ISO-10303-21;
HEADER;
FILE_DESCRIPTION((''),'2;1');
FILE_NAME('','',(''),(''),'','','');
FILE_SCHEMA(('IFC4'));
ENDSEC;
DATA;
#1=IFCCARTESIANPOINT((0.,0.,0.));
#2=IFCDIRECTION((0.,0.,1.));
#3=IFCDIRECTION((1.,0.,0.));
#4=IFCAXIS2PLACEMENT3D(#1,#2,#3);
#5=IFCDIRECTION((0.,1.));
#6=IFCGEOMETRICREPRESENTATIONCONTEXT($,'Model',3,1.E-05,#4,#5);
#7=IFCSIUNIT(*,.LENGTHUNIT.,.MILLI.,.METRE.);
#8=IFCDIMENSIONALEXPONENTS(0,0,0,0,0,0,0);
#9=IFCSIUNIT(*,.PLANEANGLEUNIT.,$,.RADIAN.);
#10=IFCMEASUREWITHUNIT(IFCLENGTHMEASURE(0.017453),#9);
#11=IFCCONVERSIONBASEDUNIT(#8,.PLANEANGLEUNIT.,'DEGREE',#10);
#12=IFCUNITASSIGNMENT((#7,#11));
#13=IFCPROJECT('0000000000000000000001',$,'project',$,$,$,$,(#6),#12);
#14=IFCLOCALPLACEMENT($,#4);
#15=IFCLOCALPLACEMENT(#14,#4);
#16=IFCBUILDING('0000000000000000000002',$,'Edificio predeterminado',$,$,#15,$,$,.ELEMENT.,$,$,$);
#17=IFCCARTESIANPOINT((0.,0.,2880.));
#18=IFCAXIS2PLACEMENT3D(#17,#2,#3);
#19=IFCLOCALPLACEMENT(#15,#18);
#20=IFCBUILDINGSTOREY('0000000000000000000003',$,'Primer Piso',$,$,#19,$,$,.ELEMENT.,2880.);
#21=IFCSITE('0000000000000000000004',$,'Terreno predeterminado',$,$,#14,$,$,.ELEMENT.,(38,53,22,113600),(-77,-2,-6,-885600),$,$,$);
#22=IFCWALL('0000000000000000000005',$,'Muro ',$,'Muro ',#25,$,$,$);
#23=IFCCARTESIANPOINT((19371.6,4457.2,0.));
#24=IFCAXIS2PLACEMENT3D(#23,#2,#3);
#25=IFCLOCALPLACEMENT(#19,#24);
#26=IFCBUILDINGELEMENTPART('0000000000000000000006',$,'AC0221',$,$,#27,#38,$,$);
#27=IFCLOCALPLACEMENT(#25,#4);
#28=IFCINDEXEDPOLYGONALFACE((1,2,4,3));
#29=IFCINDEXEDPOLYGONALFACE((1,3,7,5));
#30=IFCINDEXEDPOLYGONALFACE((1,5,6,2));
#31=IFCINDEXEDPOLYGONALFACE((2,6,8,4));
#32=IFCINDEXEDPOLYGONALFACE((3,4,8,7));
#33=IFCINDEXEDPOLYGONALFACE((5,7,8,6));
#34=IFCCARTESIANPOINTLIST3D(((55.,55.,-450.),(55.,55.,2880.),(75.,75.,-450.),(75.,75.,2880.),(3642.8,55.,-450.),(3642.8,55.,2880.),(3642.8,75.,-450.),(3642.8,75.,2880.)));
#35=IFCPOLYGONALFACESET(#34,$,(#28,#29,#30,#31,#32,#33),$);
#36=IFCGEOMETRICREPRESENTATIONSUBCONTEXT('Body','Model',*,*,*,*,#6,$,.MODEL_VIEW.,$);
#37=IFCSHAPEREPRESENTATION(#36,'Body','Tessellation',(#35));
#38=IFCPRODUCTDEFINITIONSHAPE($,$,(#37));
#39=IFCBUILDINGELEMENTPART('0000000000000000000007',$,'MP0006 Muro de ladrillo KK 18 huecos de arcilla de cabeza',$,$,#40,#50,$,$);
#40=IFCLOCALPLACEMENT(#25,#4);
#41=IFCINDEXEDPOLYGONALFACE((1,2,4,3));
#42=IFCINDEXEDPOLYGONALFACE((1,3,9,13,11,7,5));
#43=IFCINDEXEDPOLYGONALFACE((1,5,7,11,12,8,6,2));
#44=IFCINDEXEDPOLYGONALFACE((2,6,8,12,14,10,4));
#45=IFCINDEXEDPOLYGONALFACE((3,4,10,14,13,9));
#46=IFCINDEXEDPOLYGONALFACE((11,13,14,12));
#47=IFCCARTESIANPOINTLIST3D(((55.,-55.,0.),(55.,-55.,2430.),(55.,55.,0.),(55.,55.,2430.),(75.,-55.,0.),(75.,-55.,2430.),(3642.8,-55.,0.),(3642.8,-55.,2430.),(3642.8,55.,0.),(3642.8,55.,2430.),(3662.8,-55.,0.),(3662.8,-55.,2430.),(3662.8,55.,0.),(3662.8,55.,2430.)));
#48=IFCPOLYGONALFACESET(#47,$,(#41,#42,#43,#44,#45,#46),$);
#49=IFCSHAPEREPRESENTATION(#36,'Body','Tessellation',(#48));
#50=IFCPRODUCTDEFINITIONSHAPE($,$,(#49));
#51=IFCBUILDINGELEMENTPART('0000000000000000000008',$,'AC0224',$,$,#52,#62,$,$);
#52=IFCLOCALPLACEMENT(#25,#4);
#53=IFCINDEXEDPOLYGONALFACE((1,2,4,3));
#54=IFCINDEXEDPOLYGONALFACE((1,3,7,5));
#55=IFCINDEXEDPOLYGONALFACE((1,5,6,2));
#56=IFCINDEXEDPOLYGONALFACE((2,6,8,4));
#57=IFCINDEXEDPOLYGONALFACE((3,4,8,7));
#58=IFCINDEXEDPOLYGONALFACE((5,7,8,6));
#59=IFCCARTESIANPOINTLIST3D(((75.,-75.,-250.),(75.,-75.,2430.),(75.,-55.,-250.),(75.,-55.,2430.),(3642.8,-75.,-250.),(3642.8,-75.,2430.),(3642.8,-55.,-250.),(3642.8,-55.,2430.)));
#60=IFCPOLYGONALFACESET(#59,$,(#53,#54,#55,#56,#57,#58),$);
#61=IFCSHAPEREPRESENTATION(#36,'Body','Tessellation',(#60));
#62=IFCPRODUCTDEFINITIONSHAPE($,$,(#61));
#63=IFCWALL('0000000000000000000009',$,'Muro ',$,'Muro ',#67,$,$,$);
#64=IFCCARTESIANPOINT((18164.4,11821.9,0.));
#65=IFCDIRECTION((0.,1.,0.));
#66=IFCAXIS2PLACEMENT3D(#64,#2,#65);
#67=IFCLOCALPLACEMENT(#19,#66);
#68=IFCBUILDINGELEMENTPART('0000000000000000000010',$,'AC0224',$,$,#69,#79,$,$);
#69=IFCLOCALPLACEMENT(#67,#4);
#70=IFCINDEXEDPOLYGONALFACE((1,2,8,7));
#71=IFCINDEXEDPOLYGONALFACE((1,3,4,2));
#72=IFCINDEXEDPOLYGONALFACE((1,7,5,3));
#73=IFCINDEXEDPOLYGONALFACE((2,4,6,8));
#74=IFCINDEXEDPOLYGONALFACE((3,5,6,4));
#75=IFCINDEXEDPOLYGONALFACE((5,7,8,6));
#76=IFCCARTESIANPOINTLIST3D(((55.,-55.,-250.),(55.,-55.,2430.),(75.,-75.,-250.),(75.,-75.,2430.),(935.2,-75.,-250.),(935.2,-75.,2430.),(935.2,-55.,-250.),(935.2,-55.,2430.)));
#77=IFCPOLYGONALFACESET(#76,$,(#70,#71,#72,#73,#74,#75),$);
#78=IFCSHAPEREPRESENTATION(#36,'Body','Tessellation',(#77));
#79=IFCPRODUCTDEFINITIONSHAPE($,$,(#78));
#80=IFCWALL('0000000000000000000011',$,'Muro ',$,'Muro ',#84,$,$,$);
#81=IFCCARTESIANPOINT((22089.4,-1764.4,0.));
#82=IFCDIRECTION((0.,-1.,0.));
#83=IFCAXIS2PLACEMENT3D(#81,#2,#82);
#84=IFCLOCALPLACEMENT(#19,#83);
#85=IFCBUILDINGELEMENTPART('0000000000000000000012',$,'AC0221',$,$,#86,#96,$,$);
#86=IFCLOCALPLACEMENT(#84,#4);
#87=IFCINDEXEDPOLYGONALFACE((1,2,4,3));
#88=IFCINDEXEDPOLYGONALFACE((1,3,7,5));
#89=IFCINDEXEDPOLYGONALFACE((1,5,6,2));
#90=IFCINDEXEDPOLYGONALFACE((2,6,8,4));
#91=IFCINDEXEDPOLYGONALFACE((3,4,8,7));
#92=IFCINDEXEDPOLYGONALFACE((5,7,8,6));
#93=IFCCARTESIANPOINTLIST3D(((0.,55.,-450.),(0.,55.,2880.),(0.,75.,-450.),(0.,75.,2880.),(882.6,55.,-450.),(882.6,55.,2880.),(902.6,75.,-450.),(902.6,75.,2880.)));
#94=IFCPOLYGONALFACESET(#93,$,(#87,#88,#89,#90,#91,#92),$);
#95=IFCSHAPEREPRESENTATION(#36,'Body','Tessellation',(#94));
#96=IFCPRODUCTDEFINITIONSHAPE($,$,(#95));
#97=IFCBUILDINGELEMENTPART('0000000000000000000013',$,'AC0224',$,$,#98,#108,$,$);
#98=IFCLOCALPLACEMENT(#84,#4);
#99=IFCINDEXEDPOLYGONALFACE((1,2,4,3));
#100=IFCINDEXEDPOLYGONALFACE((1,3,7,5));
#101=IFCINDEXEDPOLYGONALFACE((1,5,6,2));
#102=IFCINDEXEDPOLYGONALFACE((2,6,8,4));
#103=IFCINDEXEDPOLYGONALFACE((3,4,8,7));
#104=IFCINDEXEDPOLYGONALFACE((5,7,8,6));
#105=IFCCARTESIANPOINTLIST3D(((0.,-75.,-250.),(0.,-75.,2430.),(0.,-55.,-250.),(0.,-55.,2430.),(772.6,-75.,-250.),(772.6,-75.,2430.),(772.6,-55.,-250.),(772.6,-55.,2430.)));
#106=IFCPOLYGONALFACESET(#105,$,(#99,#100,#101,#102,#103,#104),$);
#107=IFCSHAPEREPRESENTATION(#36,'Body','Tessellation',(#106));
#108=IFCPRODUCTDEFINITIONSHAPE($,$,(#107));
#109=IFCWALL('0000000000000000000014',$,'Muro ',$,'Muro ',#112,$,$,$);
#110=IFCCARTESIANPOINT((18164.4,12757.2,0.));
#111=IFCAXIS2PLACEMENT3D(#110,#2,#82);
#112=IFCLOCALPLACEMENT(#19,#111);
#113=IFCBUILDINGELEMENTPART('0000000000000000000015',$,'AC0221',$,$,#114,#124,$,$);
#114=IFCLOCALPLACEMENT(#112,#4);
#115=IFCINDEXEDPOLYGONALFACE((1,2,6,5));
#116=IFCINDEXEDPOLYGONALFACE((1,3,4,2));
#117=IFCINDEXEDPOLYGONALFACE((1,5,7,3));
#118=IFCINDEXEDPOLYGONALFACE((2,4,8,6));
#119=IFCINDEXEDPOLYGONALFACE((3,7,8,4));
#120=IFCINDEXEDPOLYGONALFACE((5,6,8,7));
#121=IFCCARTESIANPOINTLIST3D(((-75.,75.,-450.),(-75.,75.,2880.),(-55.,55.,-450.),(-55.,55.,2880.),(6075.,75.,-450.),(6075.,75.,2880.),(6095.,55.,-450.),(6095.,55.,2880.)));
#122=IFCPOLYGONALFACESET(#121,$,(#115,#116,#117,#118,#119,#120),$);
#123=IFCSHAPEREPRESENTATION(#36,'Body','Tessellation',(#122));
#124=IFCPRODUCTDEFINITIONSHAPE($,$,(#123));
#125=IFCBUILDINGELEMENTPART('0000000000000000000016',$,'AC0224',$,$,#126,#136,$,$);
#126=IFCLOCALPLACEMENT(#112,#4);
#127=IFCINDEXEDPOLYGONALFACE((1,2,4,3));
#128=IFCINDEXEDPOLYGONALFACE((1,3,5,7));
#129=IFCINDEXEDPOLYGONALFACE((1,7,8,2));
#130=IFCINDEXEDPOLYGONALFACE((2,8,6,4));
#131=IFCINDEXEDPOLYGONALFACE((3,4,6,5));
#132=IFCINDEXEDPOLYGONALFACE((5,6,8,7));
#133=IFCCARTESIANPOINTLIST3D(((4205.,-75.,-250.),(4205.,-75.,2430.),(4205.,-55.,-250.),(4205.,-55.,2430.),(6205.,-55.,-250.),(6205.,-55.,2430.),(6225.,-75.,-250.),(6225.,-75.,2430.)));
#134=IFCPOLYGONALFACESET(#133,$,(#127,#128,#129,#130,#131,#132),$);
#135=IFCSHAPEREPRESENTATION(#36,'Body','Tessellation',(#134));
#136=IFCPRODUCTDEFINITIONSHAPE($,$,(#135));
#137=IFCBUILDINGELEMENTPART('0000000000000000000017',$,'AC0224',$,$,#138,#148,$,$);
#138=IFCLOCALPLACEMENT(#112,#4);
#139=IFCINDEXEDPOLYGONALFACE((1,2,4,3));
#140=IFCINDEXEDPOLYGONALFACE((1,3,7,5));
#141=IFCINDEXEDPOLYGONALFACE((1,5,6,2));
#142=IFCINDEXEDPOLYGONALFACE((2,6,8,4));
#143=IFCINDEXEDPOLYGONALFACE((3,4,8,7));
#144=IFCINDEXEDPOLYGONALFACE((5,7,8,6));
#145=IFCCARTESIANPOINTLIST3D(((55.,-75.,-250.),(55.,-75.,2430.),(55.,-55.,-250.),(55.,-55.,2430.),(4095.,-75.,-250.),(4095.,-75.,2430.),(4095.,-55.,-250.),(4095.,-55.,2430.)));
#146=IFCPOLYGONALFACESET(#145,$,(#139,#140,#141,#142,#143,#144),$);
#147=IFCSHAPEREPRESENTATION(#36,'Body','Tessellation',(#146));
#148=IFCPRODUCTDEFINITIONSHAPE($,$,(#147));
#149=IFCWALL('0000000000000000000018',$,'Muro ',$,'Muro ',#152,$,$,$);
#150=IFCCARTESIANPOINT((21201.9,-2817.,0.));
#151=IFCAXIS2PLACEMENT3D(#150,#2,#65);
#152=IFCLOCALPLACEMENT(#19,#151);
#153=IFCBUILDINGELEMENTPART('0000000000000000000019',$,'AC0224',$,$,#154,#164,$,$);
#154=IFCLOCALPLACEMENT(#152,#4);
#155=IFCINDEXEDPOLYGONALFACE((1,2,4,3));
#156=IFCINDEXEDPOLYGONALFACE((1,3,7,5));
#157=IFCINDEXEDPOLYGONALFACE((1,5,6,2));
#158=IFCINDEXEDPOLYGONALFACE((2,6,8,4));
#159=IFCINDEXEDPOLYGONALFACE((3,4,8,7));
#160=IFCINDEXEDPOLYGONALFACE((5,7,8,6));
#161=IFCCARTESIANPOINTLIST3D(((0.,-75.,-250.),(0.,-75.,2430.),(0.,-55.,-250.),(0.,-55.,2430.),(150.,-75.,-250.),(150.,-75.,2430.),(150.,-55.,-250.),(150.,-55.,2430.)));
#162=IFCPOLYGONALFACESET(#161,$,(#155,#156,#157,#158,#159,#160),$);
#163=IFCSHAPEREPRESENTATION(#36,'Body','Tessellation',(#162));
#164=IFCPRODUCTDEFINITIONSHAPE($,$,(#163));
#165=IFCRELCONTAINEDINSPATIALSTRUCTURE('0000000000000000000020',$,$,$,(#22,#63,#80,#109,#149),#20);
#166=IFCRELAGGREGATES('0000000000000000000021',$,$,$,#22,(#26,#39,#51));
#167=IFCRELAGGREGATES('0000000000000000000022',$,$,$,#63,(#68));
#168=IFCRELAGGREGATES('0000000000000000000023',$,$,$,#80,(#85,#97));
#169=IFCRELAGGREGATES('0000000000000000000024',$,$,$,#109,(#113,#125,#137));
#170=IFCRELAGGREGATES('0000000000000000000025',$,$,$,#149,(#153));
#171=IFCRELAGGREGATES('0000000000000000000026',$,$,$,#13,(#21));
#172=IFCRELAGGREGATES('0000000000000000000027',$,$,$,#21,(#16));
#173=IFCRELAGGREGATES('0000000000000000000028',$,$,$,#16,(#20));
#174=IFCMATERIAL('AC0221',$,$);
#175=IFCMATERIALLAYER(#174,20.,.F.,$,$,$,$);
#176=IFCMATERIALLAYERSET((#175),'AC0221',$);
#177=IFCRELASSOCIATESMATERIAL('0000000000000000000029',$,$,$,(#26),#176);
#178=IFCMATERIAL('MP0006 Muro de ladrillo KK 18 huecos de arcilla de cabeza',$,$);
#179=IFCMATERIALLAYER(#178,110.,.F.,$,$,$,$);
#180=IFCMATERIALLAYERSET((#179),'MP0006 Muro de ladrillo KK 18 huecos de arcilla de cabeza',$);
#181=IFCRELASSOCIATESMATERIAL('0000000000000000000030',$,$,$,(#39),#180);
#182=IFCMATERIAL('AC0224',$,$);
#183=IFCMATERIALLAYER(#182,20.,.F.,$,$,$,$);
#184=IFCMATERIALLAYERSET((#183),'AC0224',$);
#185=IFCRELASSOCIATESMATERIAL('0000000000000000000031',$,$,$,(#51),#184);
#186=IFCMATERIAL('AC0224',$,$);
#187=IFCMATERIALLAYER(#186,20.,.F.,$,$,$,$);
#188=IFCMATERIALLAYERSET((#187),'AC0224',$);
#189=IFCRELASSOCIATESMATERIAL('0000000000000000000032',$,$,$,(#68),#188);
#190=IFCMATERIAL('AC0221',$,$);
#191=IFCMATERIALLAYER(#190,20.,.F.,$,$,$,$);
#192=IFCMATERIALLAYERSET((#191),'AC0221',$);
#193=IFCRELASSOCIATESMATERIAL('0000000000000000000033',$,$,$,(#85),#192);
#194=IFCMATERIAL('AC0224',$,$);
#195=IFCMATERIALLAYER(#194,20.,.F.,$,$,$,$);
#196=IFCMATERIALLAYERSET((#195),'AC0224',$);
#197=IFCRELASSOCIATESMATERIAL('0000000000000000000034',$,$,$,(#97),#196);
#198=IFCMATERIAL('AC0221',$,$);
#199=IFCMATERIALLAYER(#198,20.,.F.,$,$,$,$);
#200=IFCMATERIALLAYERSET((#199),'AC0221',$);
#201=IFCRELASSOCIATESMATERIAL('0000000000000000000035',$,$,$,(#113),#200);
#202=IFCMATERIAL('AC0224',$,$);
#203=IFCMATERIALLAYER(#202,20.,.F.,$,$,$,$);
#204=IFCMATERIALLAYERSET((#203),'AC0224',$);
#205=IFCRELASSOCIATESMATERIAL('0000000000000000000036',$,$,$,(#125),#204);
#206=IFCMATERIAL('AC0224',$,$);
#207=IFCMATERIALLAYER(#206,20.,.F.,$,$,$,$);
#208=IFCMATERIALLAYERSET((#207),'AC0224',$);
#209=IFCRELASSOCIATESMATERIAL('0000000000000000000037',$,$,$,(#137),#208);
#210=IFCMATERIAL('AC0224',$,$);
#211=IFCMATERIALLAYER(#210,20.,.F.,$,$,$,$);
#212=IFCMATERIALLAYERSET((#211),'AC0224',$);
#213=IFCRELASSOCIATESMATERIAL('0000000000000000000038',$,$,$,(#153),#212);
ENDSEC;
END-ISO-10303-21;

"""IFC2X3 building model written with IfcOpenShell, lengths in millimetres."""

from ifc_helpers import new_model, entity, si_unit, converted_unit, direction, frame, origin_with_axes, place, context, subcontext, project, spatial, polyline, outline, extrude, clip, bounded_halfspace, material, layer, layer_set, layer_usage, element, aggregate, save


model = new_model("IFC2X3")

# Units and contexts
model_context = context("Model", 3, precision=1e-05, world=origin_with_axes(), true_north=direction((0.0, 1.0)))
body_context = subcontext(model_context, "Body", "Model", "MODEL_VIEW")
ifc_project = project(units=[si_unit("LENGTHUNIT", "METRE", prefix="MILLI"), converted_unit("PLANEANGLEUNIT", "DEGREE", entity("IfcLengthMeasure", 0.017453), si_unit("PLANEANGLEUNIT", "RADIAN"), dimensions=[0, 0, 0, 0, 0, 0, 0])], contexts=[model_context])

# Site, building, storey
site_placement = place(None, origin_with_axes())
site = spatial("IfcSite", under=ifc_project, at=site_placement, Name="Terreno predeterminado", CompositionType="ELEMENT", RefLatitude=(38, 53, 22, 113600), RefLongitude=(-77, -2, -6, -885600))
building_placement = place(site_placement, origin_with_axes())
building = spatial("IfcBuilding", under=site, at=building_placement, Name="Edificio predeterminado", CompositionType="ELEMENT")
storey_placement = place(building_placement, frame((0.0, 0.0, 2880.0), z_axis=(0.0, 0.0, 1.0), x_axis=(1.0, 0.0, 0.0)))
storey = spatial("IfcBuildingStorey", under=building, at=storey_placement, Name="Primer Piso", CompositionType="ELEMENT", Elevation=2880.0)

# Walls, building element parts
wall_1_placement = place(storey_placement, frame((19371.6, 4457.2, 0.0), z_axis=(0.0, 0.0, 1.0), x_axis=(1.0, 0.0, 0.0)))
wall_1 = element("IfcWall", 1, at=wall_1_placement, inside=storey, Name="Muro ", ObjectType="Muro ")
ifc_material_1 = material(Name="AC0221")
ifc_layer_1 = layer(ifc_material_1, 20.0, ventilated=False)
ifc_layer_set_1 = layer_set([ifc_layer_1], Name="AC0221")
ifc_layer_usage_1 = layer_usage(ifc_layer_set_1, "AXIS2", "NEGATIVE", -75.0)
building_element_part_1_placement = place(wall_1_placement, origin_with_axes())
building_element_part_1 = element("IfcBuildingElementPart", 2, at=building_element_part_1_placement, material=ifc_layer_usage_1, Name="AC0221", context=body_context, shape_type="SweptSolid", body=[
    extrude(outline(polyline([(3642.8, 75.0), (3642.8, 55.0), (55.0, 55.0), (75.0, 75.0), (3642.8, 75.0)])), frame((0.0, 0.0, -450.0), z_axis=(0.0, 0.0, 1.0), x_axis=(1.0, 0.0, 0.0)), (0.0, 0.0, 1.0), 3330.0),
])
ifc_material_2 = material(Name="MP0006 Muro de ladrillo KK 18 huecos de arcilla de cabeza")
ifc_layer_2 = layer(ifc_material_2, 110.0, ventilated=False)
ifc_layer_set_2 = layer_set([ifc_layer_2], Name="MP0006 Muro de ladrillo KK 18 huecos de arcilla de cabeza")
ifc_layer_usage_2 = layer_usage(ifc_layer_set_2, "AXIS2", "NEGATIVE", -55.0)
building_element_part_2_placement = place(wall_1_placement, origin_with_axes())
building_element_part_2 = element("IfcBuildingElementPart", 3, at=building_element_part_2_placement, material=ifc_layer_usage_2, Name="MP0006 Muro de ladrillo KK 18 huecos de arcilla de cabeza", context=body_context, shape_type="SweptSolid", body=[
    extrude(outline(polyline([(3662.8, 55.0), (3662.8, -55.0), (3642.8, -55.0), (75.0, -55.0), (55.0, -55.0), (55.0, 55.0), (3642.8, 55.0), (3662.8, 55.0)])), origin_with_axes(), (0.0, 0.0, 1.0), 2430.0),
])
ifc_material_3 = material(Name="AC0224")
ifc_layer_3 = layer(ifc_material_3, 20.0, ventilated=False)
ifc_layer_set_3 = layer_set([ifc_layer_3], Name="AC0224")
ifc_layer_usage_3 = layer_usage(ifc_layer_set_3, "AXIS2", "NEGATIVE", 55.0)
building_element_part_3_placement = place(wall_1_placement, origin_with_axes())
building_element_part_3 = element("IfcBuildingElementPart", 4, at=building_element_part_3_placement, material=ifc_layer_usage_3, Name="AC0224", context=body_context, shape_type="SweptSolid", body=[
    extrude(outline(polyline([(3642.8, -55.0), (3642.8, -75.0), (75.0, -75.0), (75.0, -55.0), (3642.8, -55.0)])), frame((0.0, 0.0, -250.0), z_axis=(0.0, 0.0, 1.0), x_axis=(1.0, 0.0, 0.0)), (0.0, 0.0, 1.0), 2680.0),
])
aggregate(wall_1, [building_element_part_1, building_element_part_2, building_element_part_3])
wall_2_placement = place(storey_placement, frame((18164.4, 11821.9, 0.0), z_axis=(0.0, 0.0, 1.0), x_axis=(0.0, 1.0, 0.0)))
wall_2 = element("IfcWall", 5, at=wall_2_placement, inside=storey, Name="Muro ", ObjectType="Muro ")
ifc_material_4 = material(Name="AC0224")
ifc_layer_4 = layer(ifc_material_4, 20.0, ventilated=False)
ifc_layer_set_4 = layer_set([ifc_layer_4], Name="AC0224")
ifc_layer_usage_4 = layer_usage(ifc_layer_set_4, "AXIS2", "NEGATIVE", 55.0)
building_element_part_4_placement = place(wall_2_placement, origin_with_axes())
building_element_part_4 = element("IfcBuildingElementPart", 6, at=building_element_part_4_placement, material=ifc_layer_usage_4, Name="AC0224", context=body_context, shape_type="SweptSolid", body=[
    extrude(outline(polyline([(935.2, -55.0), (935.2, -75.0), (75.0, -75.0), (55.0, -55.0), (935.2, -55.0)])), frame((0.0, 0.0, -250.0), z_axis=(0.0, 0.0, 1.0), x_axis=(1.0, 0.0, 0.0)), (0.0, 0.0, 1.0), 2680.0),
])
aggregate(wall_2, [building_element_part_4])
wall_3_placement = place(storey_placement, frame((22089.4, -1764.4, 0.0), z_axis=(0.0, 0.0, 1.0), x_axis=(0.0, -1.0, 0.0)))
wall_3 = element("IfcWall", 7, at=wall_3_placement, inside=storey, Name="Muro ", ObjectType="Muro ")
ifc_material_5 = material(Name="AC0221")
ifc_layer_5 = layer(ifc_material_5, 20.0, ventilated=False)
ifc_layer_set_5 = layer_set([ifc_layer_5], Name="AC0221")
ifc_layer_usage_5 = layer_usage(ifc_layer_set_5, "AXIS2", "NEGATIVE", -75.0)
building_element_part_5_placement = place(wall_3_placement, origin_with_axes())
building_element_part_5 = element("IfcBuildingElementPart", 8, at=building_element_part_5_placement, material=ifc_layer_usage_5, Name="AC0221", context=body_context, shape_type="SweptSolid", body=[
    extrude(outline(polyline([(902.6, 75.0), (882.6, 55.0), (0.0, 55.0), (0.0, 75.0), (902.6, 75.0)])), frame((0.0, 0.0, -450.0), z_axis=(0.0, 0.0, 1.0), x_axis=(1.0, 0.0, 0.0)), (0.0, 0.0, 1.0), 3330.0),
])
ifc_material_6 = material(Name="AC0224")
ifc_layer_6 = layer(ifc_material_6, 20.0, ventilated=False)
ifc_layer_set_6 = layer_set([ifc_layer_6], Name="AC0224")
ifc_layer_usage_6 = layer_usage(ifc_layer_set_6, "AXIS2", "NEGATIVE", 55.0)
building_element_part_6_placement = place(wall_3_placement, origin_with_axes())
building_element_part_6 = element("IfcBuildingElementPart", 9, at=building_element_part_6_placement, material=ifc_layer_usage_6, Name="AC0224", context=body_context, shape_type="SweptSolid", body=[
    extrude(outline(polyline([(772.6, -55.0), (772.6, -75.0), (0.0, -75.0), (0.0, -55.0), (772.6, -55.0)])), frame((0.0, 0.0, -250.0), z_axis=(0.0, 0.0, 1.0), x_axis=(1.0, 0.0, 0.0)), (0.0, 0.0, 1.0), 2680.0),
])
aggregate(wall_3, [building_element_part_5, building_element_part_6])
wall_4_placement = place(storey_placement, frame((18164.4, 12757.2, 0.0), z_axis=(0.0, 0.0, 1.0), x_axis=(0.0, -1.0, 0.0)))
wall_4 = element("IfcWall", 10, at=wall_4_placement, inside=storey, Name="Muro ", ObjectType="Muro ")
ifc_material_7 = material(Name="AC0221")
ifc_layer_7 = layer(ifc_material_7, 20.0, ventilated=False)
ifc_layer_set_7 = layer_set([ifc_layer_7], Name="AC0221")
ifc_layer_usage_7 = layer_usage(ifc_layer_set_7, "AXIS2", "NEGATIVE", -75.0)
building_element_part_7_placement = place(wall_4_placement, origin_with_axes())
building_element_part_7 = element("IfcBuildingElementPart", 11, at=building_element_part_7_placement, material=ifc_layer_usage_7, Name="AC0221", context=body_context, shape_type="SweptSolid", body=[
    extrude(outline(polyline([(6075.0, 75.0), (6095.0, 55.0), (-55.0, 55.0), (-75.0, 75.0), (6075.0, 75.0)])), frame((0.0, 0.0, -450.0), z_axis=(0.0, 0.0, 1.0), x_axis=(1.0, 0.0, 0.0)), (0.0, 0.0, 1.0), 3330.0),
])
ifc_material_8 = material(Name="AC0224")
ifc_layer_8 = layer(ifc_material_8, 20.0, ventilated=False)
ifc_layer_set_8 = layer_set([ifc_layer_8], Name="AC0224")
ifc_layer_usage_8 = layer_usage(ifc_layer_set_8, "AXIS2", "NEGATIVE", 55.0)
building_element_part_8_placement = place(wall_4_placement, origin_with_axes())
building_element_part_8 = element("IfcBuildingElementPart", 12, at=building_element_part_8_placement, material=ifc_layer_usage_8, Name="AC0224", context=body_context, shape_type="SweptSolid", body=[
    extrude(outline(polyline([(6205.0, -55.0), (6225.0, -75.0), (4205.0, -75.0), (4205.0, -55.0), (6205.0, -55.0)])), frame((0.0, 0.0, -250.0), z_axis=(0.0, 0.0, 1.0), x_axis=(1.0, 0.0, 0.0)), (0.0, 0.0, 1.0), 2680.0),
])
ifc_material_9 = material(Name="AC0224")
ifc_layer_9 = layer(ifc_material_9, 20.0, ventilated=False)
ifc_layer_set_9 = layer_set([ifc_layer_9], Name="AC0224")
ifc_layer_usage_9 = layer_usage(ifc_layer_set_9, "AXIS2", "NEGATIVE", 55.0)
building_element_part_9_placement = place(wall_4_placement, origin_with_axes())
building_element_part_9 = element("IfcBuildingElementPart", 13, at=building_element_part_9_placement, material=ifc_layer_usage_9, Name="AC0224", context=body_context, shape_type="SweptSolid", body=[
    extrude(outline(polyline([(4095.0, -55.0), (4095.0, -75.0), (55.0, -75.0), (55.0, -55.0), (4095.0, -55.0)])), frame((0.0, 0.0, -250.0), z_axis=(0.0, 0.0, 1.0), x_axis=(1.0, 0.0, 0.0)), (0.0, 0.0, 1.0), 2680.0),
])
aggregate(wall_4, [building_element_part_7, building_element_part_8, building_element_part_9])
wall_5_placement = place(storey_placement, frame((21201.9, -2817.0, 0.0), z_axis=(0.0, 0.0, 1.0), x_axis=(0.0, 1.0, 0.0)))
wall_5 = element("IfcWall", 14, at=wall_5_placement, inside=storey, Name="Muro ", ObjectType="Muro ")
ifc_material_10 = material(Name="AC0224")
ifc_layer_10 = layer(ifc_material_10, 20.0, ventilated=False)
ifc_layer_set_10 = layer_set([ifc_layer_10], Name="AC0224")
ifc_layer_usage_10 = layer_usage(ifc_layer_set_10, "AXIS2", "NEGATIVE", 55.0)
building_element_part_10_placement = place(wall_5_placement, origin_with_axes())
building_element_part_10 = element("IfcBuildingElementPart", 15, at=building_element_part_10_placement, material=ifc_layer_usage_10, Name="AC0224", context=body_context, shape_type="Clipping", body=[
    clip(clip(extrude(outline(polyline([(150.0, -55.0), (150.0, -75.0), (0.0, -75.0), (0.0, -55.0), (150.0, -55.0)])), frame((0.0, 0.0, -250.0), z_axis=(0.0, 0.0, 1.0), x_axis=(1.0, 0.0, 0.0)), (0.0, 0.0, 1.0), 2680.0), bounded_halfspace(frame((0.0, 0.0, -250.0), z_axis=(0.0, 0.0, 1.0), x_axis=(1.0, 0.0, 0.0)), True, origin_with_axes(), polyline([(-150.0, -150.0), (375.0, -150.0), (375.0, 150.0), (-150.0, 150.0), (-150.0, -150.0)]))), bounded_halfspace(frame((0.0, 0.0, 2430.0), z_axis=(0.0, 0.0, 1.0), x_axis=(1.0, 0.0, 0.0)), False, origin_with_axes(), polyline([(-150.0, -150.0), (375.0, -150.0), (375.0, 150.0), (-150.0, 150.0), (-150.0, -150.0)]))),
])
aggregate(wall_5, [building_element_part_10])

save(model, "model.ifc")
